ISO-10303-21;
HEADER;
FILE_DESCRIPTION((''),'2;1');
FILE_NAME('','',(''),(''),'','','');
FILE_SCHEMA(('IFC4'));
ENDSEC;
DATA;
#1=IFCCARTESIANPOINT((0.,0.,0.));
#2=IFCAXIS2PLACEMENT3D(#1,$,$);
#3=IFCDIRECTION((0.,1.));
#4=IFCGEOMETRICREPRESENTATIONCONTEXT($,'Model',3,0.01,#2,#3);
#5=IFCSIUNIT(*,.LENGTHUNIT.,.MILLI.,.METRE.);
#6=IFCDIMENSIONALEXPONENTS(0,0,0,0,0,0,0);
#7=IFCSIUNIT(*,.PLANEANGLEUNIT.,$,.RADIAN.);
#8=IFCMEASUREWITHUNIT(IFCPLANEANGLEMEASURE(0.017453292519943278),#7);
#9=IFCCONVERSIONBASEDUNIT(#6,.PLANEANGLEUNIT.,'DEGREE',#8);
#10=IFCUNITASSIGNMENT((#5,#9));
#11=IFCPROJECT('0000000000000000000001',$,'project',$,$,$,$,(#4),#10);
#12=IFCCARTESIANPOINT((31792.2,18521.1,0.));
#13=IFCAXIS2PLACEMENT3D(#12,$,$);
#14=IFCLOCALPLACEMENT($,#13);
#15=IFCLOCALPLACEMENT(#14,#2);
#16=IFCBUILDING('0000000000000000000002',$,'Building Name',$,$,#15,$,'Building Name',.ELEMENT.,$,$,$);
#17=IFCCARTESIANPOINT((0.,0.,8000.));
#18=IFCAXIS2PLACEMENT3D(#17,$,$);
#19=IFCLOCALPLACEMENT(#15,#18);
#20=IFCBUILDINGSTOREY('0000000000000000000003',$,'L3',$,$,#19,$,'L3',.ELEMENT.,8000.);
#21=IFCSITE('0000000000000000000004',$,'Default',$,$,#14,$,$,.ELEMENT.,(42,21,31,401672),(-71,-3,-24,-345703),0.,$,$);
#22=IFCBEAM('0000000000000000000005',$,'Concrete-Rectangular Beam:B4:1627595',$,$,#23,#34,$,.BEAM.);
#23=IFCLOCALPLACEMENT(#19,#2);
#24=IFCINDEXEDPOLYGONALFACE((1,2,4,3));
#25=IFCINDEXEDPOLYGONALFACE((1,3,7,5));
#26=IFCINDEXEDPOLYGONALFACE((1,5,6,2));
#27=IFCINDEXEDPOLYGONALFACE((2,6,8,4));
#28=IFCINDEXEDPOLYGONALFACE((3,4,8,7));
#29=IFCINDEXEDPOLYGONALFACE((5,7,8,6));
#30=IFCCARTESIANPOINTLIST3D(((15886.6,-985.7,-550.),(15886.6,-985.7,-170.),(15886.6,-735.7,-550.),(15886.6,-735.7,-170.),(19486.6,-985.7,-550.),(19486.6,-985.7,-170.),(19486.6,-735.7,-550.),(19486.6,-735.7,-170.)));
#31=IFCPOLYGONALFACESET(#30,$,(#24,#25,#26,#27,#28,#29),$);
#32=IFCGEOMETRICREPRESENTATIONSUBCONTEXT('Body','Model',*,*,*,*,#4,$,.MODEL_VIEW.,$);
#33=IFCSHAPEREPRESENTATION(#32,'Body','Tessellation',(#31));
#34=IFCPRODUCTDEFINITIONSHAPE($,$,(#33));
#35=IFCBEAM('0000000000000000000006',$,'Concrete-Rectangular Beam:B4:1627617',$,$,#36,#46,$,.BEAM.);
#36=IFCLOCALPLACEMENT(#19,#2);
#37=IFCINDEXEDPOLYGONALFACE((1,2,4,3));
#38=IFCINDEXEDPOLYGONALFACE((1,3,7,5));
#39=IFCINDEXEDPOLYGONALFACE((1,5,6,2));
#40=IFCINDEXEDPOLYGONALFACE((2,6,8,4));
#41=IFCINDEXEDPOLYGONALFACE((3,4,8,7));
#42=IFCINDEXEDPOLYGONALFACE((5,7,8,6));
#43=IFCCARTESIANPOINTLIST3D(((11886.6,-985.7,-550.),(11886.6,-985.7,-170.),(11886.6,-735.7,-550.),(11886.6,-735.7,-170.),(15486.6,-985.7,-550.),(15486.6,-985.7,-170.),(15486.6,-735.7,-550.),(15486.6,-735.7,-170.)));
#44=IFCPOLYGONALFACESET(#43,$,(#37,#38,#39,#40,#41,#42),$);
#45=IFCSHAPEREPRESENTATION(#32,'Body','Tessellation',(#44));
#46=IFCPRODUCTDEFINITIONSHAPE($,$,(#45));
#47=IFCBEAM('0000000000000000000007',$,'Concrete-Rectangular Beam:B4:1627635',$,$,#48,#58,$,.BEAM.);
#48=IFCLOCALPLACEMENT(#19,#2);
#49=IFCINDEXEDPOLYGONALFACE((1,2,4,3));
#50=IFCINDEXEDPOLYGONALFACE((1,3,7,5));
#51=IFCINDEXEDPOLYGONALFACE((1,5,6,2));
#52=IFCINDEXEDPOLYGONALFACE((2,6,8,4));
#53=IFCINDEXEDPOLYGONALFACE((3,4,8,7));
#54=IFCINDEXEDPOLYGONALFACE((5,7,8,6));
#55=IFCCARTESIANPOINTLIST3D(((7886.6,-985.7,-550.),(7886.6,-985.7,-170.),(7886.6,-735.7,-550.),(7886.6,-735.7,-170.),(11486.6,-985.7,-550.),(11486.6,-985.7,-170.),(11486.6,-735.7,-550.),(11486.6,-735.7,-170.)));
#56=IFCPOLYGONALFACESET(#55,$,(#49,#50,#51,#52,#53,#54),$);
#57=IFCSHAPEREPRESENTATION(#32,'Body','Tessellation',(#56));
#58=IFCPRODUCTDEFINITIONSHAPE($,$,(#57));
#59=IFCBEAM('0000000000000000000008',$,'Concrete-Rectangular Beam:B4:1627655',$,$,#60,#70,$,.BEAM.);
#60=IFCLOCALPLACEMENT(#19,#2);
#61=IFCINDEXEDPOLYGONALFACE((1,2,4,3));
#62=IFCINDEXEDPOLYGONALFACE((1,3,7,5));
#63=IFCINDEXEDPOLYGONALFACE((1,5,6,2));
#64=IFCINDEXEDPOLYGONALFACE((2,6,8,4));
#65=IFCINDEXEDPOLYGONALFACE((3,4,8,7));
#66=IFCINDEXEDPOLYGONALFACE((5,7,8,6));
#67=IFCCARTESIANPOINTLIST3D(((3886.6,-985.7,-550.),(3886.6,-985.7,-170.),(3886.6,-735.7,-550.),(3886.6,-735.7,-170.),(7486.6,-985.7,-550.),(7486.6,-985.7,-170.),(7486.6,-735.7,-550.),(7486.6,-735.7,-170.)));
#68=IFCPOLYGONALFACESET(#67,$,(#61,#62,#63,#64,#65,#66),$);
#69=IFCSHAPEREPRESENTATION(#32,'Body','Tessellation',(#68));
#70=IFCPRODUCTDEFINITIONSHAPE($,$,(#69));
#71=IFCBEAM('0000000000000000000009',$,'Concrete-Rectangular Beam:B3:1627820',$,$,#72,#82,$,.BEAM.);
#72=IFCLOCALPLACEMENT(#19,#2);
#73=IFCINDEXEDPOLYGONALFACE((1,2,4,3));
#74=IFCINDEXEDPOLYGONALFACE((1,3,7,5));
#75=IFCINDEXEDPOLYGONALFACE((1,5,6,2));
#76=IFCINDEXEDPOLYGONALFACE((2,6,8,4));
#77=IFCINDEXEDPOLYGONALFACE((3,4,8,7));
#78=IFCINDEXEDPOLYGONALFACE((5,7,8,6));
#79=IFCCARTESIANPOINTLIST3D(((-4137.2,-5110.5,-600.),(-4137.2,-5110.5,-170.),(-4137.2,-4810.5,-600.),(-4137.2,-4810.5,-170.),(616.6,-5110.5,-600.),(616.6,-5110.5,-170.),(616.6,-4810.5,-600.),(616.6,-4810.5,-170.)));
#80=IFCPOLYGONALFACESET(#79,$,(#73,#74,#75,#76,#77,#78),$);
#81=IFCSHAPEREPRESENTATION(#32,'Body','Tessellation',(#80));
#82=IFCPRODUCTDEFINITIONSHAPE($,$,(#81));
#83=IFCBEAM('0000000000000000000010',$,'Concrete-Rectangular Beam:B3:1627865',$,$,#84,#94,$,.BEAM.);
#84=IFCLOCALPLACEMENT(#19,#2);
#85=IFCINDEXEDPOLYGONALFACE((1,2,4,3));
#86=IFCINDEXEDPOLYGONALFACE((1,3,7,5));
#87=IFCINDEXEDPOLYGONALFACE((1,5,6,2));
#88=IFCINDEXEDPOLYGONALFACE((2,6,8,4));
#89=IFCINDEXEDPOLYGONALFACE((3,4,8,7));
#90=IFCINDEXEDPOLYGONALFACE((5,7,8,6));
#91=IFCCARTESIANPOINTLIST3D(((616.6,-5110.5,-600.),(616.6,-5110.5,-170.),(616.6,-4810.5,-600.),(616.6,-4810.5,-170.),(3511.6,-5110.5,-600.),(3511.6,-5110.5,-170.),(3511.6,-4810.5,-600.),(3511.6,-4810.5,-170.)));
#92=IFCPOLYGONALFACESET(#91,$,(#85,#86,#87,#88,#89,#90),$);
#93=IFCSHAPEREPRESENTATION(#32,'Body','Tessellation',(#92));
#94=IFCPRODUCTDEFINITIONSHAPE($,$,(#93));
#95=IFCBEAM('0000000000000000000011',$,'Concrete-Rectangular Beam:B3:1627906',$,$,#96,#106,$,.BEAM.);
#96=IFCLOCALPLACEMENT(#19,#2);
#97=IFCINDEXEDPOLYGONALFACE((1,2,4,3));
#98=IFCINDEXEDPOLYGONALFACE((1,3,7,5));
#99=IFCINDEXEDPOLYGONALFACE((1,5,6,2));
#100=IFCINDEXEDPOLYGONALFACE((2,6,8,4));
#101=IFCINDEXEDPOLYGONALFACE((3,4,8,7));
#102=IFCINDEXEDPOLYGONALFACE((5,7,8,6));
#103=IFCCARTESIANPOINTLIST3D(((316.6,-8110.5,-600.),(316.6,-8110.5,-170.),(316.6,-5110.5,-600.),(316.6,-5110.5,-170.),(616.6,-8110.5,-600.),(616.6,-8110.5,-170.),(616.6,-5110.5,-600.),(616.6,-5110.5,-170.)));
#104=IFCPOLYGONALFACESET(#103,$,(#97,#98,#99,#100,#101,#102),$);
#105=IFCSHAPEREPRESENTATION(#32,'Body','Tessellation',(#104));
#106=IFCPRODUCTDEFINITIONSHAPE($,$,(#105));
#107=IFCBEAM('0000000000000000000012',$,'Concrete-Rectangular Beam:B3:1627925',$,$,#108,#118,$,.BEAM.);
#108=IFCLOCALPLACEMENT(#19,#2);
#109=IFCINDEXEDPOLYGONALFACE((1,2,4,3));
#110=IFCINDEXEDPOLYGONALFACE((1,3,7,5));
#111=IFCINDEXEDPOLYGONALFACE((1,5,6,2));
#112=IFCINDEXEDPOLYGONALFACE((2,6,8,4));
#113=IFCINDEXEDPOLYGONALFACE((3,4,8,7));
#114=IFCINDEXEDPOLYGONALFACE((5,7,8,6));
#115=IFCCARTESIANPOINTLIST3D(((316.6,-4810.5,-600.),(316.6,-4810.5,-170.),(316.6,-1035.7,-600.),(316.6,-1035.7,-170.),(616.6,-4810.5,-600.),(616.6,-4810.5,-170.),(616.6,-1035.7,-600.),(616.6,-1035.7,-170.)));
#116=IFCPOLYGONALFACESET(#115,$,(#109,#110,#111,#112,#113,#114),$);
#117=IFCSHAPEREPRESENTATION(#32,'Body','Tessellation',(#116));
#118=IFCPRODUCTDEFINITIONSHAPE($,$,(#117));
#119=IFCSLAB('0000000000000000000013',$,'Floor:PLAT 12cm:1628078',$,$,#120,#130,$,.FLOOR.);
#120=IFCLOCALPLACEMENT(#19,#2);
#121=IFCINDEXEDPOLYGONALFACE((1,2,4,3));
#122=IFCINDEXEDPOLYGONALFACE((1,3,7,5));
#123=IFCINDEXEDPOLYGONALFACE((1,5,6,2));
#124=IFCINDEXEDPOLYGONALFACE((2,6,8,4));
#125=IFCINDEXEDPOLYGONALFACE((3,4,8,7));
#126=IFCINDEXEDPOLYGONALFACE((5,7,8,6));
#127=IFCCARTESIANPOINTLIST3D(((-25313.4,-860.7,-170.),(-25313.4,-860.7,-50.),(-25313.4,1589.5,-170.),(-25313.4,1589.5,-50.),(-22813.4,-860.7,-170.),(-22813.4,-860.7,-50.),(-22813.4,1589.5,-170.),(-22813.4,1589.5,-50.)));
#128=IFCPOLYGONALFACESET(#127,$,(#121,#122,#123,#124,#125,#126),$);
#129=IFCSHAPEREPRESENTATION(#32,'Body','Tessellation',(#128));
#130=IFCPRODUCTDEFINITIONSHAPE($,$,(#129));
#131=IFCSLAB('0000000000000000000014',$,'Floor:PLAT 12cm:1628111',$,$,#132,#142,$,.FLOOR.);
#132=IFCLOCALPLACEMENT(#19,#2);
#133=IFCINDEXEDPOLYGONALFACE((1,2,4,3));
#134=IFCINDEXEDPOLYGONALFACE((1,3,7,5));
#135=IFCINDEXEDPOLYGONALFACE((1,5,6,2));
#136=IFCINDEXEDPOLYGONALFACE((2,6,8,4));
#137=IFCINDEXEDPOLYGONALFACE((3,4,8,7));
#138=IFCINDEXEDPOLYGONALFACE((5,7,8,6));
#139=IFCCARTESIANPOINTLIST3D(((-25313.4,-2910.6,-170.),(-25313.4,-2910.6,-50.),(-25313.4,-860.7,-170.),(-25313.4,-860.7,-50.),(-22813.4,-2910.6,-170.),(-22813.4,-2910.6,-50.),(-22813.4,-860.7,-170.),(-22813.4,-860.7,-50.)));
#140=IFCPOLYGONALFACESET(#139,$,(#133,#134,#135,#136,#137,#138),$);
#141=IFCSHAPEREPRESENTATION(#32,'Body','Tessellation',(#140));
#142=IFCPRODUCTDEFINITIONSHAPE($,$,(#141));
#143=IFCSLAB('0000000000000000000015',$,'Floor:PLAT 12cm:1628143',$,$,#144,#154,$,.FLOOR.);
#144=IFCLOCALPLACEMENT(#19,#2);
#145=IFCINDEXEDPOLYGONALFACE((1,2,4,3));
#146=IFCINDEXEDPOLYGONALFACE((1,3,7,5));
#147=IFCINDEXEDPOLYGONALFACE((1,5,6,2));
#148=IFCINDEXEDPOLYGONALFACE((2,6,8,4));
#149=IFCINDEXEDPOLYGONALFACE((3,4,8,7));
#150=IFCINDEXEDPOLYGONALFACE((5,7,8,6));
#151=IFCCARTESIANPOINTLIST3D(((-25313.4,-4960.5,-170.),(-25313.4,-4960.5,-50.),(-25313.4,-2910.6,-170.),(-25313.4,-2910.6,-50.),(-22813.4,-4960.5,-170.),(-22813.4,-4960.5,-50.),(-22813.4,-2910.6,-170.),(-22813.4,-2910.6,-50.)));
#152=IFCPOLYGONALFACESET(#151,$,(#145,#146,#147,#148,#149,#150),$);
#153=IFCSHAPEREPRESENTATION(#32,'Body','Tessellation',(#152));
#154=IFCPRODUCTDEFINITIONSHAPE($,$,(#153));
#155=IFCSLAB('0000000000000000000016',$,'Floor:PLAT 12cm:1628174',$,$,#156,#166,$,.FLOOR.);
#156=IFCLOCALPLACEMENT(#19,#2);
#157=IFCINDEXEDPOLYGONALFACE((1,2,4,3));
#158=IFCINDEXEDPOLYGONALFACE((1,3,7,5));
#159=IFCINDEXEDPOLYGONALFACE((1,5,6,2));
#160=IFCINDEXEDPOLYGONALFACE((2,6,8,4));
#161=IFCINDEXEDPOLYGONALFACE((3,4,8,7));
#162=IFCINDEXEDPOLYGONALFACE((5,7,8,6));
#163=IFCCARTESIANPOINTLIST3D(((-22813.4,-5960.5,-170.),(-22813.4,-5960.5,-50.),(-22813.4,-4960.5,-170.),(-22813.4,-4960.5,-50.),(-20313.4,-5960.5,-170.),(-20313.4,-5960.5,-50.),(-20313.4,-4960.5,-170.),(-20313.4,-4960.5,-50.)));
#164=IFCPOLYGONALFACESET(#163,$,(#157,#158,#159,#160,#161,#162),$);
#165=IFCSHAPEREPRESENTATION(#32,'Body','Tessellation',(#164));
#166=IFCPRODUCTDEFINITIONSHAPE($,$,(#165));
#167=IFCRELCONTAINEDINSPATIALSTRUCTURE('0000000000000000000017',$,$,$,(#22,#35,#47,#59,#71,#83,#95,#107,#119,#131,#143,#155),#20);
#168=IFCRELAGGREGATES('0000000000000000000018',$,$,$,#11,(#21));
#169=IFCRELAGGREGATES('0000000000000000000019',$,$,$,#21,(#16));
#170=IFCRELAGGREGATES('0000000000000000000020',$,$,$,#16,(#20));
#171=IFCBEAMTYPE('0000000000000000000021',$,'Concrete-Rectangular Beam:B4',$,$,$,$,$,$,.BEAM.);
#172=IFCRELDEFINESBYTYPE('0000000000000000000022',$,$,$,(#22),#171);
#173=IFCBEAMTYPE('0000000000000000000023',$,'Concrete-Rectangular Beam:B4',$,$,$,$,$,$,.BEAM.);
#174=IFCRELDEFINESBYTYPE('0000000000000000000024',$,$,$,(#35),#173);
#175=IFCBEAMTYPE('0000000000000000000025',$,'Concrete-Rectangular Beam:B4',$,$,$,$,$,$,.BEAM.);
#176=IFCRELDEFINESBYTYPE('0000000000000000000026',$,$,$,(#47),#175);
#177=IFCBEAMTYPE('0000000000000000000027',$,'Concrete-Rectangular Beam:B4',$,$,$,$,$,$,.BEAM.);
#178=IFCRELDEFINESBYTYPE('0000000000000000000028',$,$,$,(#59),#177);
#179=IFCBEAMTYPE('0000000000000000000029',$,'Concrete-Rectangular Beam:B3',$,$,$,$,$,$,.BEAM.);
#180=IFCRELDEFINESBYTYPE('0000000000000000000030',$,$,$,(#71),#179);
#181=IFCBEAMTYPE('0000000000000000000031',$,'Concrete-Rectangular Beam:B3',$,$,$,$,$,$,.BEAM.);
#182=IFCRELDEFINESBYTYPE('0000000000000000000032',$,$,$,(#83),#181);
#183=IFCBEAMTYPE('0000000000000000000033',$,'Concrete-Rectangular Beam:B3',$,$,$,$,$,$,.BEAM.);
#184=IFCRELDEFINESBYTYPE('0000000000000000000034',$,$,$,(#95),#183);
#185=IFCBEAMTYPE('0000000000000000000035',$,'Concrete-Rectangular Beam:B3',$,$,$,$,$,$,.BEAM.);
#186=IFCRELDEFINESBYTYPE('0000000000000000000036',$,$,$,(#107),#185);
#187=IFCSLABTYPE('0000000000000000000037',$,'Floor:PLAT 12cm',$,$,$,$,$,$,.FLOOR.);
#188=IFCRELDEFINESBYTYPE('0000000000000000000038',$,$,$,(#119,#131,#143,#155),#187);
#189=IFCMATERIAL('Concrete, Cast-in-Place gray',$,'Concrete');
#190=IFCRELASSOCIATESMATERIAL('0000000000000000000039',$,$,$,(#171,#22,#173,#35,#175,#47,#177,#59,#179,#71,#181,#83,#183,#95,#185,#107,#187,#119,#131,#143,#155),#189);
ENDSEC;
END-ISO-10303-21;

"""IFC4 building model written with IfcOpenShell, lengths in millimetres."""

from ifc_helpers import new_model, entity, si_unit, converted_unit, direction, frame, origin, place, context, subcontext, project, spatial, indexed_curve, outline, extrude, source, transform, mapped, material, type_object, type_shapes, element, save


model = new_model("IFC4")

# Units and contexts
model_context = context("Model", 3, precision=0.01, world=origin(), true_north=direction((0.0, 1.0)))
body_context = subcontext(model_context, "Body", "Model", "MODEL_VIEW")
ifc_project = project(units=[si_unit("LENGTHUNIT", "METRE", prefix="MILLI"), converted_unit("PLANEANGLEUNIT", "DEGREE", entity("IfcPlaneAngleMeasure", 0.017453292519943278), si_unit("PLANEANGLEUNIT", "RADIAN"), dimensions=[0, 0, 0, 0, 0, 0, 0])], contexts=[model_context])

# Site, building, storey
site_placement = place(None, frame((31792.2, 18521.1, 0.0)))
site = spatial("IfcSite", under=ifc_project, at=site_placement, Name="Default", CompositionType="ELEMENT", RefLatitude=(42, 21, 31, 401672), RefLongitude=(-71, -3, -24, -345703), RefElevation=0.0)
building_placement = place(site_placement, origin())
building = spatial("IfcBuilding", under=site, at=building_placement, Name="Building Name", LongName="Building Name", CompositionType="ELEMENT")
storey_placement = place(building_placement, frame((0.0, 0.0, 8000.0)))
storey = spatial("IfcBuildingStorey", under=building, at=storey_placement, Name="L3", LongName="L3", CompositionType="ELEMENT", Elevation=8000.0)

# Beams
ifc_material = material(Name="Concrete, Cast-in-Place gray", Category="Concrete")
beam_type_1 = type_object("IfcBeamType", Name="Concrete-Rectangular Beam:B4", PredefinedType="BEAM", material=ifc_material)
shared_shape_1 = source(origin(), body_context, "Body", "SweptSolid", [
    extrude(outline(indexed_curve([(-190.0, -125.0), (190.0, -125.0), (190.0, 125.0), (-190.0, 125.0), (-190.0, -125.0)], self_intersect=False)), frame((19486.6, -860.7, 7640.0), z_axis=(-1.0, 0.0, 0.0), x_axis=(0.0, 0.0, -1.0)), (0.0, 0.0, 1.0), 3600.0),
])
type_shapes(beam_type_1, [shared_shape_1])
beam_1_placement = place(storey_placement, frame((0.0, 0.0, -8000.0)))
element("IfcBeam", 1, at=beam_1_placement, inside=storey, type_object=beam_type_1, material=ifc_material, Name="Concrete-Rectangular Beam:B4:1627595", PredefinedType="BEAM", context=body_context, shape_type="MappedRepresentation", body=[
    mapped(shared_shape_1, transform((0.0, 0.0, 0.0), scale=1.0)),
])
beam_type_2 = type_object("IfcBeamType", Name="Concrete-Rectangular Beam:B4", PredefinedType="BEAM", material=ifc_material)
shared_shape_2 = source(origin(), body_context, "Body", "SweptSolid", [
    extrude(outline(indexed_curve([(-190.0, -125.0), (190.0, -125.0), (190.0, 125.0), (-190.0, 125.0), (-190.0, -125.0)], self_intersect=False)), frame((15486.6, -860.7, 7640.0), z_axis=(-1.0, 0.0, 0.0), x_axis=(0.0, 0.0, -1.0)), (0.0, 0.0, 1.0), 3600.0),
])
type_shapes(beam_type_2, [shared_shape_2])
beam_2_placement = place(storey_placement, frame((0.0, 0.0, -8000.0)))
element("IfcBeam", 2, at=beam_2_placement, inside=storey, type_object=beam_type_2, material=ifc_material, Name="Concrete-Rectangular Beam:B4:1627617", PredefinedType="BEAM", context=body_context, shape_type="MappedRepresentation", body=[
    mapped(shared_shape_2, transform((0.0, 0.0, 0.0), scale=1.0)),
])
beam_type_3 = type_object("IfcBeamType", Name="Concrete-Rectangular Beam:B4", PredefinedType="BEAM", material=ifc_material)
shared_shape_3 = source(origin(), body_context, "Body", "SweptSolid", [
    extrude(outline(indexed_curve([(-190.0, -125.0), (190.0, -125.0), (190.0, 125.0), (-190.0, 125.0), (-190.0, -125.0)], self_intersect=False)), frame((11486.6, -860.7, 7640.0), z_axis=(-1.0, 0.0, 0.0), x_axis=(0.0, 0.0, -1.0)), (0.0, 0.0, 1.0), 3600.0),
])
type_shapes(beam_type_3, [shared_shape_3])
beam_3_placement = place(storey_placement, frame((0.0, 0.0, -8000.0)))
element("IfcBeam", 3, at=beam_3_placement, inside=storey, type_object=beam_type_3, material=ifc_material, Name="Concrete-Rectangular Beam:B4:1627635", PredefinedType="BEAM", context=body_context, shape_type="MappedRepresentation", body=[
    mapped(shared_shape_3, transform((0.0, 0.0, 0.0), scale=1.0)),
])
beam_type_4 = type_object("IfcBeamType", Name="Concrete-Rectangular Beam:B4", PredefinedType="BEAM", material=ifc_material)
shared_shape_4 = source(origin(), body_context, "Body", "SweptSolid", [
    extrude(outline(indexed_curve([(-190.0, -125.0), (190.0, -125.0), (190.0, 125.0), (-190.0, 125.0), (-190.0, -125.0)], self_intersect=False)), frame((7486.6, -860.7, 7640.0), z_axis=(-1.0, 0.0, 0.0), x_axis=(0.0, 0.0, -1.0)), (0.0, 0.0, 1.0), 3600.0),
])
type_shapes(beam_type_4, [shared_shape_4])
beam_4_placement = place(storey_placement, frame((0.0, 0.0, -8000.0)))
element("IfcBeam", 4, at=beam_4_placement, inside=storey, type_object=beam_type_4, material=ifc_material, Name="Concrete-Rectangular Beam:B4:1627655", PredefinedType="BEAM", context=body_context, shape_type="MappedRepresentation", body=[
    mapped(shared_shape_4, transform((0.0, 0.0, 0.0), scale=1.0)),
])
beam_type_5 = type_object("IfcBeamType", Name="Concrete-Rectangular Beam:B3", PredefinedType="BEAM", material=ifc_material)
shared_shape_5 = source(origin(), body_context, "Body", "SweptSolid", [
    extrude(outline(indexed_curve([(-215.0, -150.0), (215.0, -150.0), (215.0, 150.0), (-215.0, 150.0), (-215.0, -150.0)], self_intersect=False)), frame((-4137.2, -4960.5, 7615.0), z_axis=(1.0, 0.0, 0.0), x_axis=(0.0, 0.0, -1.0)), (0.0, 0.0, 1.0), 4753.8),
])
type_shapes(beam_type_5, [shared_shape_5])
beam_5_placement = place(storey_placement, frame((0.0, 0.0, -8000.0)))
element("IfcBeam", 5, at=beam_5_placement, inside=storey, type_object=beam_type_5, material=ifc_material, Name="Concrete-Rectangular Beam:B3:1627820", PredefinedType="BEAM", context=body_context, shape_type="MappedRepresentation", body=[
    mapped(shared_shape_5, transform((0.0, 0.0, 0.0), scale=1.0)),
])
beam_type_6 = type_object("IfcBeamType", Name="Concrete-Rectangular Beam:B3", PredefinedType="BEAM", material=ifc_material)
shared_shape_6 = source(origin(), body_context, "Body", "SweptSolid", [
    extrude(outline(indexed_curve([(-215.0, -150.0), (215.0, -150.0), (215.0, 150.0), (-215.0, 150.0), (-215.0, -150.0)], self_intersect=False)), frame((616.6, -4960.5, 7615.0), z_axis=(1.0, 0.0, 0.0), x_axis=(0.0, 0.0, -1.0)), (0.0, 0.0, 1.0), 2895.0),
])
type_shapes(beam_type_6, [shared_shape_6])
beam_6_placement = place(storey_placement, frame((0.0, 0.0, -8000.0)))
element("IfcBeam", 6, at=beam_6_placement, inside=storey, type_object=beam_type_6, material=ifc_material, Name="Concrete-Rectangular Beam:B3:1627865", PredefinedType="BEAM", context=body_context, shape_type="MappedRepresentation", body=[
    mapped(shared_shape_6, transform((0.0, 0.0, 0.0), scale=1.0)),
])
beam_type_7 = type_object("IfcBeamType", Name="Concrete-Rectangular Beam:B3", PredefinedType="BEAM", material=ifc_material)
shared_shape_7 = source(origin(), body_context, "Body", "SweptSolid", [
    extrude(outline(indexed_curve([(-150.0, -215.0), (150.0, -215.0), (150.0, 215.0), (-150.0, 215.0), (-150.0, -215.0)], self_intersect=False)), frame((466.6, -8110.5, 7615.0), z_axis=(0.0, 1.0, 0.0), x_axis=(-1.0, 0.0, 0.0)), (0.0, 0.0, 1.0), 3000.0),
])
type_shapes(beam_type_7, [shared_shape_7])
beam_7_placement = place(storey_placement, frame((0.0, 0.0, -8000.0)))
element("IfcBeam", 7, at=beam_7_placement, inside=storey, type_object=beam_type_7, material=ifc_material, Name="Concrete-Rectangular Beam:B3:1627906", PredefinedType="BEAM", context=body_context, shape_type="MappedRepresentation", body=[
    mapped(shared_shape_7, transform((0.0, 0.0, 0.0), scale=1.0)),
])
beam_type_8 = type_object("IfcBeamType", Name="Concrete-Rectangular Beam:B3", PredefinedType="BEAM", material=ifc_material)
shared_shape_8 = source(origin(), body_context, "Body", "SweptSolid", [
    extrude(outline(indexed_curve([(-150.0, -215.0), (150.0, -215.0), (150.0, 215.0), (-150.0, 215.0), (-150.0, -215.0)], self_intersect=False)), frame((466.6, -4810.5, 7615.0), z_axis=(0.0, 1.0, 0.0), x_axis=(-1.0, 0.0, 0.0)), (0.0, 0.0, 1.0), 3774.8),
])
type_shapes(beam_type_8, [shared_shape_8])
beam_8_placement = place(storey_placement, frame((0.0, 0.0, -8000.0)))
element("IfcBeam", 8, at=beam_8_placement, inside=storey, type_object=beam_type_8, material=ifc_material, Name="Concrete-Rectangular Beam:B3:1627925", PredefinedType="BEAM", context=body_context, shape_type="MappedRepresentation", body=[
    mapped(shared_shape_8, transform((0.0, 0.0, 0.0), scale=1.0)),
])

# Slabs
slab_type = type_object("IfcSlabType", Name="Floor:PLAT 12cm", PredefinedType="FLOOR", material=ifc_material)
slab_1_placement = place(storey_placement, origin())
element("IfcSlab", 9, at=slab_1_placement, inside=storey, type_object=slab_type, material=ifc_material, Name="Floor:PLAT 12cm:1628078", PredefinedType="FLOOR", context=body_context, shape_type="SweptSolid", body=[
    extrude(outline(indexed_curve([(-1225.1, -1250.0), (1225.1, -1250.0), (1225.1, 1250.0), (-1225.1, 1250.0), (-1225.1, -1250.0)], self_intersect=False)), frame((-24063.4, 364.4, -50.0), z_axis=(0.0, 0.0, -1.0), x_axis=(0.0, 1.0, 0.0)), (0.0, 0.0, 1.0), 120.0),
])
slab_2_placement = place(storey_placement, origin())
element("IfcSlab", 10, at=slab_2_placement, inside=storey, type_object=slab_type, material=ifc_material, Name="Floor:PLAT 12cm:1628111", PredefinedType="FLOOR", context=body_context, shape_type="SweptSolid", body=[
    extrude(outline(indexed_curve([(-1024.9, -1250.0), (1024.9, -1250.0), (1024.9, 1250.0), (-1024.9, 1250.0), (-1024.9, -1250.0)], self_intersect=False)), frame((-24063.4, -1885.7, -50.0), z_axis=(0.0, 0.0, -1.0), x_axis=(0.0, 1.0, 0.0)), (0.0, 0.0, 1.0), 120.0),
])
slab_3_placement = place(storey_placement, origin())
element("IfcSlab", 11, at=slab_3_placement, inside=storey, type_object=slab_type, material=ifc_material, Name="Floor:PLAT 12cm:1628143", PredefinedType="FLOOR", context=body_context, shape_type="SweptSolid", body=[
    extrude(outline(indexed_curve([(-1024.9, -1250.0), (1024.9, -1250.0), (1024.9, 1250.0), (-1024.9, 1250.0), (-1024.9, -1250.0)], self_intersect=False)), frame((-24063.4, -3935.6, -50.0), z_axis=(0.0, 0.0, -1.0), x_axis=(0.0, 1.0, 0.0)), (0.0, 0.0, 1.0), 120.0),
])
slab_4_placement = place(storey_placement, origin())
element("IfcSlab", 12, at=slab_4_placement, inside=storey, type_object=slab_type, material=ifc_material, Name="Floor:PLAT 12cm:1628174", PredefinedType="FLOOR", context=body_context, shape_type="SweptSolid", body=[
    extrude(outline(indexed_curve([(-500.0, -1250.0), (500.0, -1250.0), (500.0, 1250.0), (-500.0, 1250.0), (-500.0, -1250.0)], self_intersect=False)), frame((-21563.4, -5460.5, -50.0), z_axis=(0.0, 0.0, -1.0), x_axis=(0.0, 1.0, 0.0)), (0.0, 0.0, 1.0), 120.0),
])

save(model, "model.ifc")
